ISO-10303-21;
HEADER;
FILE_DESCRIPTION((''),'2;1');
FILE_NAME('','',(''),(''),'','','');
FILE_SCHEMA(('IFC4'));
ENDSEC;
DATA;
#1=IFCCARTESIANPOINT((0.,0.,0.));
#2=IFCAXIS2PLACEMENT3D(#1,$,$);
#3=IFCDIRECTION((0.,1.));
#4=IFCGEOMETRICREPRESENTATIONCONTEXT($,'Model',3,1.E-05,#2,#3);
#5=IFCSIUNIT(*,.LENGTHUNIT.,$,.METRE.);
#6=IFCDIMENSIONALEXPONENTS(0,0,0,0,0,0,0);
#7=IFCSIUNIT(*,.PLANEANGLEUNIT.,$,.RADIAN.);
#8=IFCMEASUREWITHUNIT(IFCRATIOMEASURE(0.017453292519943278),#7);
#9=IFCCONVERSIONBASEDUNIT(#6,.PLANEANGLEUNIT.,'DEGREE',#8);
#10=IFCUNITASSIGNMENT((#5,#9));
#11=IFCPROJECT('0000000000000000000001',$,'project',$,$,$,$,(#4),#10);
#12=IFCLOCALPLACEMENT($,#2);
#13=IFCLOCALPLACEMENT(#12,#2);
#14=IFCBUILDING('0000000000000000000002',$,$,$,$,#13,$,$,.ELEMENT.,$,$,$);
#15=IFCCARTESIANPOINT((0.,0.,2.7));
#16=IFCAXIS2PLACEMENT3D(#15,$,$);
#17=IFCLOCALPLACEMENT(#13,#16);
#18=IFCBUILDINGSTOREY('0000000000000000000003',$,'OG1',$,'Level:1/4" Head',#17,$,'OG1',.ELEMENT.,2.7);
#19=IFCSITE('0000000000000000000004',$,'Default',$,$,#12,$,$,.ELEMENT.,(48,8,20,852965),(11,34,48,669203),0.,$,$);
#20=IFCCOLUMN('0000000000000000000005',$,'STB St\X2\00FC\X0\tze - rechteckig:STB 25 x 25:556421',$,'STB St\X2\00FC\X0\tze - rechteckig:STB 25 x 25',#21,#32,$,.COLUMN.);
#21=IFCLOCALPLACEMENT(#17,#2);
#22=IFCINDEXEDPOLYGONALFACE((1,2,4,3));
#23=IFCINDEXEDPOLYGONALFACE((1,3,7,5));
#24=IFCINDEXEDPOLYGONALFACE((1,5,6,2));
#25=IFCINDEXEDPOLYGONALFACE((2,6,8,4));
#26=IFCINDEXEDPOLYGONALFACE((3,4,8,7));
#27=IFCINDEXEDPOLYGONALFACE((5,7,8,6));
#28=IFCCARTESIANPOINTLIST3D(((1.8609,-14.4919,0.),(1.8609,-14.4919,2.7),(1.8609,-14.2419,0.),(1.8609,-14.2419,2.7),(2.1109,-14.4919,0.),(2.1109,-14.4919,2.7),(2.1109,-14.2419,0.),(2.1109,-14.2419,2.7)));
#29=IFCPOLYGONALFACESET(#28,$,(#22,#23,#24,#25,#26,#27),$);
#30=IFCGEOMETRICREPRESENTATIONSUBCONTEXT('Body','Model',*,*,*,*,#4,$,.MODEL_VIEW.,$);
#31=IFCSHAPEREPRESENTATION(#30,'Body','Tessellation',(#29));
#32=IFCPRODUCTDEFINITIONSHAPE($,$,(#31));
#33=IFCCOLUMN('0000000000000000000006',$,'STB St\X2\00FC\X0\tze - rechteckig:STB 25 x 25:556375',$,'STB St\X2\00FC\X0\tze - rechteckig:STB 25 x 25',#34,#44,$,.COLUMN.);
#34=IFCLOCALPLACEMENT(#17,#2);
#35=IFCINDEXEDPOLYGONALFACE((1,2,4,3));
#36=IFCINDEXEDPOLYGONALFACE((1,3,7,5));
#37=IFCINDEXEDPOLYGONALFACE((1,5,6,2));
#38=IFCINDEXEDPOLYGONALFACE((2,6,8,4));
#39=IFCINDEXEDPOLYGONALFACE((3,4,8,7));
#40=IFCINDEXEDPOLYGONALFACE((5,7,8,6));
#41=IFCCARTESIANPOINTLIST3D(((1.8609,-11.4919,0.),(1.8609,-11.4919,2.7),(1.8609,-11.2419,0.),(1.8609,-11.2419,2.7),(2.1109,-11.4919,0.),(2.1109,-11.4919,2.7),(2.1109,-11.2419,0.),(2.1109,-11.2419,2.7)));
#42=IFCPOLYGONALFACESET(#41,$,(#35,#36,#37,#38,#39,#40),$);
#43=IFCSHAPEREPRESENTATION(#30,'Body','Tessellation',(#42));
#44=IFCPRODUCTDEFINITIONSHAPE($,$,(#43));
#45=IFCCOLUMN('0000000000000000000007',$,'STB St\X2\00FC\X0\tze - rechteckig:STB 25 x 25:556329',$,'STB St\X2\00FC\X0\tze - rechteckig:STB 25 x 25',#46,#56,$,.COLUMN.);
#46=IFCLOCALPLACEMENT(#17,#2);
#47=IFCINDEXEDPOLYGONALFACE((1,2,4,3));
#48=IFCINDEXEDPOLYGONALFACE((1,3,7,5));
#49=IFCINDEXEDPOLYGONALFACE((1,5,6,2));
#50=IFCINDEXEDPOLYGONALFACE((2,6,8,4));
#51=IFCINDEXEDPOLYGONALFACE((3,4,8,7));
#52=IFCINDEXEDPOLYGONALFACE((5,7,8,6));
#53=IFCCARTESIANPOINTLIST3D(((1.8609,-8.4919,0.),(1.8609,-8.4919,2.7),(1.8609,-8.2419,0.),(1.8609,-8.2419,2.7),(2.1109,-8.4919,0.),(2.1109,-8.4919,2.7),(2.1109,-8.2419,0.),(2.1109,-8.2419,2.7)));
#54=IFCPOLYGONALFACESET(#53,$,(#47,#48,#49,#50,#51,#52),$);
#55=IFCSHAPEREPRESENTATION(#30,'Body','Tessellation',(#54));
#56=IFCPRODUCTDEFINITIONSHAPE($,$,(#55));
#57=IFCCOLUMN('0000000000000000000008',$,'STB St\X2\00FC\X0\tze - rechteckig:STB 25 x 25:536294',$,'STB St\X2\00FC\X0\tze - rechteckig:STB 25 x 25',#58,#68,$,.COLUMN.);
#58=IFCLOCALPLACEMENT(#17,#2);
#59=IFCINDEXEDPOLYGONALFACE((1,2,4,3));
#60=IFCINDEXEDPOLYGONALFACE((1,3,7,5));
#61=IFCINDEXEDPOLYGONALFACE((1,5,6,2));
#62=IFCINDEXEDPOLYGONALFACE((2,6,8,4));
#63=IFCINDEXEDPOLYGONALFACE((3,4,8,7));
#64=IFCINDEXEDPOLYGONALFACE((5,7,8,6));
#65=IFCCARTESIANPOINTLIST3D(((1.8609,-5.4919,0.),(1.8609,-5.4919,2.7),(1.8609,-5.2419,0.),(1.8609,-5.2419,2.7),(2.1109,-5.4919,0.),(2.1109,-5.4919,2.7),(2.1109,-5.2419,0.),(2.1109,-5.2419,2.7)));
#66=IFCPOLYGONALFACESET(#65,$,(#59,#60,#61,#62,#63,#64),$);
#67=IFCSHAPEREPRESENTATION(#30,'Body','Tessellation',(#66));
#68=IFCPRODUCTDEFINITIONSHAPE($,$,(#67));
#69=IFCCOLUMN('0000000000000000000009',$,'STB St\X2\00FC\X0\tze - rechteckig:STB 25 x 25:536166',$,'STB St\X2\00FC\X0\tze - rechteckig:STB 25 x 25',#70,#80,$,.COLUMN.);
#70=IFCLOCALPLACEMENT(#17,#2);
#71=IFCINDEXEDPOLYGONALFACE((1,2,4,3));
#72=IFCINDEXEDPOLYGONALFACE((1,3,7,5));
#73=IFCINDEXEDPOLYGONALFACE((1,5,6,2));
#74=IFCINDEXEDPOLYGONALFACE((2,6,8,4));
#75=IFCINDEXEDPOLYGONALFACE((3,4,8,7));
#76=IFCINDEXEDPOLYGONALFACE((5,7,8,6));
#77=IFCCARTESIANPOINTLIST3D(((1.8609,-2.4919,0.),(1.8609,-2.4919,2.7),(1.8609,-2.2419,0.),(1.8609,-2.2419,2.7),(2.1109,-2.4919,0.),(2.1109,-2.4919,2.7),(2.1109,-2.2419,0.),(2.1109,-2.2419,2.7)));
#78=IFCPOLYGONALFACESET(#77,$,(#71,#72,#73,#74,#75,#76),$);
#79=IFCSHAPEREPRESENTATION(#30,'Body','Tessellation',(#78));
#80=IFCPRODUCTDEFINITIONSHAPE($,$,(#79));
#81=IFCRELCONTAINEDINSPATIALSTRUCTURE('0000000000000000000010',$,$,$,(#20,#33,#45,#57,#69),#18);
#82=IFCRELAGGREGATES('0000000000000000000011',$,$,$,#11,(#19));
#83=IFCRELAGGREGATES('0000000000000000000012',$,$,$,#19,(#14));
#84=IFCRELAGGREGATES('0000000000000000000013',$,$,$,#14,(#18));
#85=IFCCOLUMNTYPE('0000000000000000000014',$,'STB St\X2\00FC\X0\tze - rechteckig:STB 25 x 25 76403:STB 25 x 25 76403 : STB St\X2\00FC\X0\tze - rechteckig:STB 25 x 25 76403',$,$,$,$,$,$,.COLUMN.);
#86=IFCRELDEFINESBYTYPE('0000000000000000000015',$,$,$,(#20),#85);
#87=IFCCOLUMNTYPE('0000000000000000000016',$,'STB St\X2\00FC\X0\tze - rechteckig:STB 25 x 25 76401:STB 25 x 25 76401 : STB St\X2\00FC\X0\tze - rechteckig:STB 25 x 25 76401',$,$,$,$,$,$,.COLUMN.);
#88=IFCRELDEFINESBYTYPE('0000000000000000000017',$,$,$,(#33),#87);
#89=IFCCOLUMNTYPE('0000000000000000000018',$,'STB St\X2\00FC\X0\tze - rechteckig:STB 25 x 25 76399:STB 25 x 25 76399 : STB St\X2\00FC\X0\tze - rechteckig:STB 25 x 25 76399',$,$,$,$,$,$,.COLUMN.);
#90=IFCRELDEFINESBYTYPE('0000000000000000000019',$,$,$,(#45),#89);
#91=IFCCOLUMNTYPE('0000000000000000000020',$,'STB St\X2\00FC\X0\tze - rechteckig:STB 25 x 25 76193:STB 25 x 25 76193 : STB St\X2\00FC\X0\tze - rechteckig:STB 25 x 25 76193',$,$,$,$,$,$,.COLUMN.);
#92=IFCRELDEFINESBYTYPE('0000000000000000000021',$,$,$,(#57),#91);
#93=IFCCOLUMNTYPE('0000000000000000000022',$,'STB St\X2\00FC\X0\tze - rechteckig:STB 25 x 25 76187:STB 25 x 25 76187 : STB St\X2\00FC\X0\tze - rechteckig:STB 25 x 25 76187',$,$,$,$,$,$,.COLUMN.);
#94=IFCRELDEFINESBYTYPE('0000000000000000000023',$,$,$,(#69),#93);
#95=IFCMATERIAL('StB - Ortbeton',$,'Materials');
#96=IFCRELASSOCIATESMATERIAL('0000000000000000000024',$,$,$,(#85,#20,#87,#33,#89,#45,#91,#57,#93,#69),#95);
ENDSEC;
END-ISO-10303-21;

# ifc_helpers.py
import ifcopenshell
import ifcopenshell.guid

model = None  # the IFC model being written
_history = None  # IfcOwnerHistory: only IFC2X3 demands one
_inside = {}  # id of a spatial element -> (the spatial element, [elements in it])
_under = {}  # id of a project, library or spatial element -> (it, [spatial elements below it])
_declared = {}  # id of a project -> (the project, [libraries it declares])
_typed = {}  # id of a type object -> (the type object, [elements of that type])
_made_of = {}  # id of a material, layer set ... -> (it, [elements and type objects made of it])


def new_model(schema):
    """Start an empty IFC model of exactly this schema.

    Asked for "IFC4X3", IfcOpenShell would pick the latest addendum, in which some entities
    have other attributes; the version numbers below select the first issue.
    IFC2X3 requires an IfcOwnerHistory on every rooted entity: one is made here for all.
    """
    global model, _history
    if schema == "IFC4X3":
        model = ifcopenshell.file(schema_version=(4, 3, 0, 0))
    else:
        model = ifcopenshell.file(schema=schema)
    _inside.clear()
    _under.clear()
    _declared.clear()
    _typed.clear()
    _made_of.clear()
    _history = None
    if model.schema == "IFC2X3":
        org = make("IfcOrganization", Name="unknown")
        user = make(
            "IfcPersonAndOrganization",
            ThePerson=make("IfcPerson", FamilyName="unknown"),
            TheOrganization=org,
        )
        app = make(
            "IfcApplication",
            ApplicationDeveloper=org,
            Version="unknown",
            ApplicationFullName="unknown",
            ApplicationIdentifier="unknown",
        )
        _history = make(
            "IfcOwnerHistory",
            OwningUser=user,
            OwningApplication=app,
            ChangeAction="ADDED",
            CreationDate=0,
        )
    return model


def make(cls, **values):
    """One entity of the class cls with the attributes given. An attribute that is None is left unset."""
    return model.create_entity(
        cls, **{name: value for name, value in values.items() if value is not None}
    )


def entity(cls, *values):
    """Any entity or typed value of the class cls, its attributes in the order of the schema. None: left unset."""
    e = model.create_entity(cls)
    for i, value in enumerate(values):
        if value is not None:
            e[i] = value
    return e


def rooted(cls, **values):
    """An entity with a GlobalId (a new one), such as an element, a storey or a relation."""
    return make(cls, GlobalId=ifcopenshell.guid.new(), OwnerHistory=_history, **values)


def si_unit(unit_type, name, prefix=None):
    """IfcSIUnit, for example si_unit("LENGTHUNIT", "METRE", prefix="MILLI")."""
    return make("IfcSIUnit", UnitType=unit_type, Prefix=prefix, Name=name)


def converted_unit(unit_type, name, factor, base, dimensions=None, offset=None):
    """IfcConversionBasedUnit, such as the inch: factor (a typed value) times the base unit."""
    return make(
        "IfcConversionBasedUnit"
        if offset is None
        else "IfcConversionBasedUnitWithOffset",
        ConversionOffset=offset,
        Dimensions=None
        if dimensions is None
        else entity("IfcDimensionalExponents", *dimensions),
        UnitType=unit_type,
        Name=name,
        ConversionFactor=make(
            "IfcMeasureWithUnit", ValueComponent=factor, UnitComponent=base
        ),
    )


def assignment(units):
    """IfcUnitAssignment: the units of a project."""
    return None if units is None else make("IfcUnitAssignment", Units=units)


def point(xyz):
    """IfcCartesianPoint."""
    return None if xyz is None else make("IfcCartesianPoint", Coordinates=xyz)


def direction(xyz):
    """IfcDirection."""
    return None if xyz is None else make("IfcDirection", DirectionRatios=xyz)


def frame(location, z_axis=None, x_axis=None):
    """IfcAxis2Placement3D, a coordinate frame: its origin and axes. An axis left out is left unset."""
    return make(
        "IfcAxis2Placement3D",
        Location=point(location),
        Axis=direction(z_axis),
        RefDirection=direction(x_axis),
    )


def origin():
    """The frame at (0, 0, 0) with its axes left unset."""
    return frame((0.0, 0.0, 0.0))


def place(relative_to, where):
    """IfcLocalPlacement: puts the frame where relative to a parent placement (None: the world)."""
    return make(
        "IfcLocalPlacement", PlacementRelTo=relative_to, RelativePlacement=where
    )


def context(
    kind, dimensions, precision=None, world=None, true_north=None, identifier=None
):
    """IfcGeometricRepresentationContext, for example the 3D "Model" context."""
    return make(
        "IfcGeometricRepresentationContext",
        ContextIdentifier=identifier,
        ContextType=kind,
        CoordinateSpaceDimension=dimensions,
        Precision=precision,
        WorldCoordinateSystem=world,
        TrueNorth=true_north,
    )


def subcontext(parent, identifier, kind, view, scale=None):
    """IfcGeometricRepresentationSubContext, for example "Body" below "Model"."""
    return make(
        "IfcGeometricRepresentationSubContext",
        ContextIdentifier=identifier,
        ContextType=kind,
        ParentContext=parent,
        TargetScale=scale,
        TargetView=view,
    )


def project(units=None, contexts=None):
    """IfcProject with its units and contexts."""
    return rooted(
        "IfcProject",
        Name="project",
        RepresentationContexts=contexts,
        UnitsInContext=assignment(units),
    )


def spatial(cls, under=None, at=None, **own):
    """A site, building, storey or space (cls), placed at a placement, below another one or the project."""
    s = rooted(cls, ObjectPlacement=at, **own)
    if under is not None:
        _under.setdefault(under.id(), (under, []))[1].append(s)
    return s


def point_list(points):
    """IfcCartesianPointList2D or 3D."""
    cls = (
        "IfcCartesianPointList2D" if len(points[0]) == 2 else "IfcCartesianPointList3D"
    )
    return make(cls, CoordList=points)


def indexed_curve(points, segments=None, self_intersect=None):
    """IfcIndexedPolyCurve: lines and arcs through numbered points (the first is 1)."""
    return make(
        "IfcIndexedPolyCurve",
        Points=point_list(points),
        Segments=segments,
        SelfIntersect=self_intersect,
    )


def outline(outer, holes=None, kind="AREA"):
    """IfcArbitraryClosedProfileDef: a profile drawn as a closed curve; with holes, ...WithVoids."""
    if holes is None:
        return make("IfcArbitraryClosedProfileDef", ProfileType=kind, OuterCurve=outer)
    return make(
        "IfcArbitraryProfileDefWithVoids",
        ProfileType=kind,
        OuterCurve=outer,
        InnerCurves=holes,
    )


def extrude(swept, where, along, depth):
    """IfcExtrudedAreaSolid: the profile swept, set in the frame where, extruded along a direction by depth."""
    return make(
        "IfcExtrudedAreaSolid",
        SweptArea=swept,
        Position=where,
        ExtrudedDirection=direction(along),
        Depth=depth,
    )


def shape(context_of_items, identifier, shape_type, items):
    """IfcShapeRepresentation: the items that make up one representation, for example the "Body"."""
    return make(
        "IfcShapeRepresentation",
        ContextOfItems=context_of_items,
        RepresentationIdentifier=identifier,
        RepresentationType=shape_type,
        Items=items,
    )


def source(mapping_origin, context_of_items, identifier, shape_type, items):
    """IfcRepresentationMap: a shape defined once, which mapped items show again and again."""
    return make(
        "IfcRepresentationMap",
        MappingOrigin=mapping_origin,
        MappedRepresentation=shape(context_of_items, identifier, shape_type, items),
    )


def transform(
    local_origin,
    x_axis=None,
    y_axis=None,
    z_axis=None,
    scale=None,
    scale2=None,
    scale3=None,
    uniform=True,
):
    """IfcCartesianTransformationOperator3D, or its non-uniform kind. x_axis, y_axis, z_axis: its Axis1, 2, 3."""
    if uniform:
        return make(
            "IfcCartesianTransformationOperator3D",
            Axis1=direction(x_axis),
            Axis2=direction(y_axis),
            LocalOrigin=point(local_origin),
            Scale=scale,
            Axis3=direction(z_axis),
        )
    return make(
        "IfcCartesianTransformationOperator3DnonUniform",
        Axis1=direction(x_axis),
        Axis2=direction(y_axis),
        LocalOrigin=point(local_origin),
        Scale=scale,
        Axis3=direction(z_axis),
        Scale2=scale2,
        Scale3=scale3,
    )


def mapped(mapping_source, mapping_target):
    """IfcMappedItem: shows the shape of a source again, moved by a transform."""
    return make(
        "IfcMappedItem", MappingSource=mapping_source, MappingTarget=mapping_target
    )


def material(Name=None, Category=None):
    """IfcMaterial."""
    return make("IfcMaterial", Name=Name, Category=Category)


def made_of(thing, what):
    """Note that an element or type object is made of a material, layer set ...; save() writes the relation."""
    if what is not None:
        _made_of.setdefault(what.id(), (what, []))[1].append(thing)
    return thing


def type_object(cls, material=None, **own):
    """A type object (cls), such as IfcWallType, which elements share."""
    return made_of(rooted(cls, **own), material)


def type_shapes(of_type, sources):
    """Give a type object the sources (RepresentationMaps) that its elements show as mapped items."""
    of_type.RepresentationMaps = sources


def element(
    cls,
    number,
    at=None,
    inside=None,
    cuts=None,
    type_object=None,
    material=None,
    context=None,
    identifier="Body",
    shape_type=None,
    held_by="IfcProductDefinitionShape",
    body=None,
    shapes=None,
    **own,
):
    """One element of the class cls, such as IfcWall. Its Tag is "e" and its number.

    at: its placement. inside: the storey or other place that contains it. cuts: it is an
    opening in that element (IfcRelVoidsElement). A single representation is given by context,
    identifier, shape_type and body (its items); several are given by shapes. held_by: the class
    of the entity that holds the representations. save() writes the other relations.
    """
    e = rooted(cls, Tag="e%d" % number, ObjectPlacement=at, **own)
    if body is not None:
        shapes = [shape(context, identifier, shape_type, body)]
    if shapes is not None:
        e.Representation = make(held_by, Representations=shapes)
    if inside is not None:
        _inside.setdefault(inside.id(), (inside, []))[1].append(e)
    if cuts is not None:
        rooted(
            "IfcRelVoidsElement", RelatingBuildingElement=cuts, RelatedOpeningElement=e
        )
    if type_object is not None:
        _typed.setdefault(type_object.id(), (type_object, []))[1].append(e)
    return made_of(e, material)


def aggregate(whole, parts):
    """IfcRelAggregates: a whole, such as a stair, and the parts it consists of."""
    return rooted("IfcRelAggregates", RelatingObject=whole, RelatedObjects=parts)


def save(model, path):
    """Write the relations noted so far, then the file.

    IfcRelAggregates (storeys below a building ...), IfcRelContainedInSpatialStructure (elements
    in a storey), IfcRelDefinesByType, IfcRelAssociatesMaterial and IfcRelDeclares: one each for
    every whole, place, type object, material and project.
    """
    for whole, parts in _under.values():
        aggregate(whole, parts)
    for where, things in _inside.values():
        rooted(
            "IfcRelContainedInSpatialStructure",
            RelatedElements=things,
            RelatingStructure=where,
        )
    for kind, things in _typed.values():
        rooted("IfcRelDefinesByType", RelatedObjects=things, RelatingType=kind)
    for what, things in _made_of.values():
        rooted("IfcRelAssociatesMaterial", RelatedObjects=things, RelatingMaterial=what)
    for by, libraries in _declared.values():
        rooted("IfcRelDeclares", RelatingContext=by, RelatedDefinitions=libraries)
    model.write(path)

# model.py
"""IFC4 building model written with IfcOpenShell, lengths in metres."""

from ifc_helpers import new_model, entity, si_unit, converted_unit, direction, frame, origin, place, context, subcontext, project, spatial, indexed_curve, outline, extrude, source, transform, mapped, material, type_object, type_shapes, element, save


model = new_model("IFC4")

# Units and contexts
model_context = context("Model", 3, precision=1e-05, world=origin(), true_north=direction((0.0, 1.0)))
body_context = subcontext(model_context, "Body", "Model", "MODEL_VIEW")
ifc_project = project(units=[si_unit("LENGTHUNIT", "METRE"), converted_unit("PLANEANGLEUNIT", "DEGREE", entity("IfcRatioMeasure", 0.017453292519943278), si_unit("PLANEANGLEUNIT", "RADIAN"), dimensions=[0, 0, 0, 0, 0, 0, 0])], contexts=[model_context])

# Site, building, storey
site_placement = place(None, origin())
site = spatial("IfcSite", under=ifc_project, at=site_placement, Name="Default", CompositionType="ELEMENT", RefLatitude=(48, 8, 20, 852965), RefLongitude=(11, 34, 48, 669203), RefElevation=0.0)
building_placement = place(site_placement, origin())
building = spatial("IfcBuilding", under=site, at=building_placement, CompositionType="ELEMENT")
storey_placement = place(building_placement, frame((0.0, 0.0, 2.7)))
storey = spatial("IfcBuildingStorey", under=building, at=storey_placement, Name="OG1", ObjectType="Level:1/4\" Head", LongName="OG1", CompositionType="ELEMENT", Elevation=2.7)

# Columns
ifc_material_1 = material(Name="StB - Ortbeton", Category="Materials")
column_type_1 = type_object("IfcColumnType", Name="STB Stütze - rechteckig:STB 25 x 25 76403:STB 25 x 25 76403 : STB Stütze - rechteckig:STB 25 x 25 76403", PredefinedType="COLUMN", material=ifc_material_1)
shared_shape_1 = source(origin(), body_context, "Body", "SweptSolid", [
    extrude(outline(indexed_curve([(-0.125, -0.125), (0.125, -0.125), (0.125, 0.125), (-0.125, 0.125), (-0.125, -0.125)], self_intersect=False)), frame((1.9859, -14.3669, 2.7), z_axis=(0.0, 0.0, 1.0), x_axis=(0.0, -1.0, 0.0)), (0.0, 0.0, 1.0), 2.7),
])
type_shapes(column_type_1, [shared_shape_1])
column_1_placement = place(storey_placement, frame((0.0, 0.0, -2.7)))
element("IfcColumn", 1, at=column_1_placement, inside=storey, type_object=column_type_1, material=ifc_material_1, Name="STB Stütze - rechteckig:STB 25 x 25:556421", ObjectType="STB Stütze - rechteckig:STB 25 x 25", PredefinedType="COLUMN", context=body_context, shape_type="MappedRepresentation", body=[
    mapped(shared_shape_1, transform((0.0, 0.0, 0.0), scale=1.0)),
])
column_type_2 = type_object("IfcColumnType", Name="STB Stütze - rechteckig:STB 25 x 25 76401:STB 25 x 25 76401 : STB Stütze - rechteckig:STB 25 x 25 76401", PredefinedType="COLUMN", material=ifc_material_1)
shared_shape_2 = source(origin(), body_context, "Body", "SweptSolid", [
    extrude(outline(indexed_curve([(-0.125, -0.125), (0.125, -0.125), (0.125, 0.125), (-0.125, 0.125), (-0.125, -0.125)], self_intersect=False)), frame((1.9859, -11.3669, 2.7), z_axis=(0.0, 0.0, 1.0), x_axis=(0.0, -1.0, 0.0)), (0.0, 0.0, 1.0), 2.7),
])
type_shapes(column_type_2, [shared_shape_2])
column_2_placement = place(storey_placement, frame((0.0, 0.0, -2.7)))
element("IfcColumn", 2, at=column_2_placement, inside=storey, type_object=column_type_2, material=ifc_material_1, Name="STB Stütze - rechteckig:STB 25 x 25:556375", ObjectType="STB Stütze - rechteckig:STB 25 x 25", PredefinedType="COLUMN", context=body_context, shape_type="MappedRepresentation", body=[
    mapped(shared_shape_2, transform((0.0, 0.0, 0.0), scale=1.0)),
])
column_type_3 = type_object("IfcColumnType", Name="STB Stütze - rechteckig:STB 25 x 25 76399:STB 25 x 25 76399 : STB Stütze - rechteckig:STB 25 x 25 76399", PredefinedType="COLUMN", material=ifc_material_1)
shared_shape_3 = source(origin(), body_context, "Body", "SweptSolid", [
    extrude(outline(indexed_curve([(-0.125, -0.125), (0.125, -0.125), (0.125, 0.125), (-0.125, 0.125), (-0.125, -0.125)], self_intersect=False)), frame((1.9859, -8.3669, 2.7), z_axis=(0.0, 0.0, 1.0), x_axis=(0.0, -1.0, 0.0)), (0.0, 0.0, 1.0), 2.7),
])
type_shapes(column_type_3, [shared_shape_3])
column_3_placement = place(storey_placement, frame((0.0, 0.0, -2.7)))
element("IfcColumn", 3, at=column_3_placement, inside=storey, type_object=column_type_3, material=ifc_material_1, Name="STB Stütze - rechteckig:STB 25 x 25:556329", ObjectType="STB Stütze - rechteckig:STB 25 x 25", PredefinedType="COLUMN", context=body_context, shape_type="MappedRepresentation", body=[
    mapped(shared_shape_3, transform((0.0, 0.0, 0.0), scale=1.0)),
])
column_type_4 = type_object("IfcColumnType", Name="STB Stütze - rechteckig:STB 25 x 25 76193:STB 25 x 25 76193 : STB Stütze - rechteckig:STB 25 x 25 76193", PredefinedType="COLUMN", material=ifc_material_1)
shared_shape_4 = source(origin(), body_context, "Body", "SweptSolid", [
    extrude(outline(indexed_curve([(-0.125, -0.125), (0.125, -0.125), (0.125, 0.125), (-0.125, 0.125), (-0.125, -0.125)], self_intersect=False)), frame((1.9859, -5.3669, 2.7), z_axis=(0.0, 0.0, 1.0), x_axis=(0.0, -1.0, 0.0)), (0.0, 0.0, 1.0), 2.7),
])
type_shapes(column_type_4, [shared_shape_4])
column_4_placement = place(storey_placement, frame((0.0, 0.0, -2.7)))
element("IfcColumn", 4, at=column_4_placement, inside=storey, type_object=column_type_4, material=ifc_material_1, Name="STB Stütze - rechteckig:STB 25 x 25:536294", ObjectType="STB Stütze - rechteckig:STB 25 x 25", PredefinedType="COLUMN", context=body_context, shape_type="MappedRepresentation", body=[
    mapped(shared_shape_4, transform((0.0, 0.0, 0.0), scale=1.0)),
])
column_type_5 = type_object("IfcColumnType", Name="STB Stütze - rechteckig:STB 25 x 25 76187:STB 25 x 25 76187 : STB Stütze - rechteckig:STB 25 x 25 76187", PredefinedType="COLUMN", material=ifc_material_1)
shared_shape_5 = source(origin(), body_context, "Body", "SweptSolid", [
    extrude(outline(indexed_curve([(-0.125, -0.125), (0.125, -0.125), (0.125, 0.125), (-0.125, 0.125), (-0.125, -0.125)], self_intersect=False)), frame((1.9859, -2.3669, 2.7), z_axis=(0.0, 0.0, 1.0), x_axis=(0.0, -1.0, 0.0)), (0.0, 0.0, 1.0), 2.7),
])
type_shapes(column_type_5, [shared_shape_5])
column_5_placement = place(storey_placement, frame((0.0, 0.0, -2.7)))
element("IfcColumn", 5, at=column_5_placement, inside=storey, type_object=column_type_5, material=ifc_material_1, Name="STB Stütze - rechteckig:STB 25 x 25:536166", ObjectType="STB Stütze - rechteckig:STB 25 x 25", PredefinedType="COLUMN", context=body_context, shape_type="MappedRepresentation", body=[
    mapped(shared_shape_5, transform((0.0, 0.0, 0.0), scale=1.0)),
])

save(model, "model.ifc")
